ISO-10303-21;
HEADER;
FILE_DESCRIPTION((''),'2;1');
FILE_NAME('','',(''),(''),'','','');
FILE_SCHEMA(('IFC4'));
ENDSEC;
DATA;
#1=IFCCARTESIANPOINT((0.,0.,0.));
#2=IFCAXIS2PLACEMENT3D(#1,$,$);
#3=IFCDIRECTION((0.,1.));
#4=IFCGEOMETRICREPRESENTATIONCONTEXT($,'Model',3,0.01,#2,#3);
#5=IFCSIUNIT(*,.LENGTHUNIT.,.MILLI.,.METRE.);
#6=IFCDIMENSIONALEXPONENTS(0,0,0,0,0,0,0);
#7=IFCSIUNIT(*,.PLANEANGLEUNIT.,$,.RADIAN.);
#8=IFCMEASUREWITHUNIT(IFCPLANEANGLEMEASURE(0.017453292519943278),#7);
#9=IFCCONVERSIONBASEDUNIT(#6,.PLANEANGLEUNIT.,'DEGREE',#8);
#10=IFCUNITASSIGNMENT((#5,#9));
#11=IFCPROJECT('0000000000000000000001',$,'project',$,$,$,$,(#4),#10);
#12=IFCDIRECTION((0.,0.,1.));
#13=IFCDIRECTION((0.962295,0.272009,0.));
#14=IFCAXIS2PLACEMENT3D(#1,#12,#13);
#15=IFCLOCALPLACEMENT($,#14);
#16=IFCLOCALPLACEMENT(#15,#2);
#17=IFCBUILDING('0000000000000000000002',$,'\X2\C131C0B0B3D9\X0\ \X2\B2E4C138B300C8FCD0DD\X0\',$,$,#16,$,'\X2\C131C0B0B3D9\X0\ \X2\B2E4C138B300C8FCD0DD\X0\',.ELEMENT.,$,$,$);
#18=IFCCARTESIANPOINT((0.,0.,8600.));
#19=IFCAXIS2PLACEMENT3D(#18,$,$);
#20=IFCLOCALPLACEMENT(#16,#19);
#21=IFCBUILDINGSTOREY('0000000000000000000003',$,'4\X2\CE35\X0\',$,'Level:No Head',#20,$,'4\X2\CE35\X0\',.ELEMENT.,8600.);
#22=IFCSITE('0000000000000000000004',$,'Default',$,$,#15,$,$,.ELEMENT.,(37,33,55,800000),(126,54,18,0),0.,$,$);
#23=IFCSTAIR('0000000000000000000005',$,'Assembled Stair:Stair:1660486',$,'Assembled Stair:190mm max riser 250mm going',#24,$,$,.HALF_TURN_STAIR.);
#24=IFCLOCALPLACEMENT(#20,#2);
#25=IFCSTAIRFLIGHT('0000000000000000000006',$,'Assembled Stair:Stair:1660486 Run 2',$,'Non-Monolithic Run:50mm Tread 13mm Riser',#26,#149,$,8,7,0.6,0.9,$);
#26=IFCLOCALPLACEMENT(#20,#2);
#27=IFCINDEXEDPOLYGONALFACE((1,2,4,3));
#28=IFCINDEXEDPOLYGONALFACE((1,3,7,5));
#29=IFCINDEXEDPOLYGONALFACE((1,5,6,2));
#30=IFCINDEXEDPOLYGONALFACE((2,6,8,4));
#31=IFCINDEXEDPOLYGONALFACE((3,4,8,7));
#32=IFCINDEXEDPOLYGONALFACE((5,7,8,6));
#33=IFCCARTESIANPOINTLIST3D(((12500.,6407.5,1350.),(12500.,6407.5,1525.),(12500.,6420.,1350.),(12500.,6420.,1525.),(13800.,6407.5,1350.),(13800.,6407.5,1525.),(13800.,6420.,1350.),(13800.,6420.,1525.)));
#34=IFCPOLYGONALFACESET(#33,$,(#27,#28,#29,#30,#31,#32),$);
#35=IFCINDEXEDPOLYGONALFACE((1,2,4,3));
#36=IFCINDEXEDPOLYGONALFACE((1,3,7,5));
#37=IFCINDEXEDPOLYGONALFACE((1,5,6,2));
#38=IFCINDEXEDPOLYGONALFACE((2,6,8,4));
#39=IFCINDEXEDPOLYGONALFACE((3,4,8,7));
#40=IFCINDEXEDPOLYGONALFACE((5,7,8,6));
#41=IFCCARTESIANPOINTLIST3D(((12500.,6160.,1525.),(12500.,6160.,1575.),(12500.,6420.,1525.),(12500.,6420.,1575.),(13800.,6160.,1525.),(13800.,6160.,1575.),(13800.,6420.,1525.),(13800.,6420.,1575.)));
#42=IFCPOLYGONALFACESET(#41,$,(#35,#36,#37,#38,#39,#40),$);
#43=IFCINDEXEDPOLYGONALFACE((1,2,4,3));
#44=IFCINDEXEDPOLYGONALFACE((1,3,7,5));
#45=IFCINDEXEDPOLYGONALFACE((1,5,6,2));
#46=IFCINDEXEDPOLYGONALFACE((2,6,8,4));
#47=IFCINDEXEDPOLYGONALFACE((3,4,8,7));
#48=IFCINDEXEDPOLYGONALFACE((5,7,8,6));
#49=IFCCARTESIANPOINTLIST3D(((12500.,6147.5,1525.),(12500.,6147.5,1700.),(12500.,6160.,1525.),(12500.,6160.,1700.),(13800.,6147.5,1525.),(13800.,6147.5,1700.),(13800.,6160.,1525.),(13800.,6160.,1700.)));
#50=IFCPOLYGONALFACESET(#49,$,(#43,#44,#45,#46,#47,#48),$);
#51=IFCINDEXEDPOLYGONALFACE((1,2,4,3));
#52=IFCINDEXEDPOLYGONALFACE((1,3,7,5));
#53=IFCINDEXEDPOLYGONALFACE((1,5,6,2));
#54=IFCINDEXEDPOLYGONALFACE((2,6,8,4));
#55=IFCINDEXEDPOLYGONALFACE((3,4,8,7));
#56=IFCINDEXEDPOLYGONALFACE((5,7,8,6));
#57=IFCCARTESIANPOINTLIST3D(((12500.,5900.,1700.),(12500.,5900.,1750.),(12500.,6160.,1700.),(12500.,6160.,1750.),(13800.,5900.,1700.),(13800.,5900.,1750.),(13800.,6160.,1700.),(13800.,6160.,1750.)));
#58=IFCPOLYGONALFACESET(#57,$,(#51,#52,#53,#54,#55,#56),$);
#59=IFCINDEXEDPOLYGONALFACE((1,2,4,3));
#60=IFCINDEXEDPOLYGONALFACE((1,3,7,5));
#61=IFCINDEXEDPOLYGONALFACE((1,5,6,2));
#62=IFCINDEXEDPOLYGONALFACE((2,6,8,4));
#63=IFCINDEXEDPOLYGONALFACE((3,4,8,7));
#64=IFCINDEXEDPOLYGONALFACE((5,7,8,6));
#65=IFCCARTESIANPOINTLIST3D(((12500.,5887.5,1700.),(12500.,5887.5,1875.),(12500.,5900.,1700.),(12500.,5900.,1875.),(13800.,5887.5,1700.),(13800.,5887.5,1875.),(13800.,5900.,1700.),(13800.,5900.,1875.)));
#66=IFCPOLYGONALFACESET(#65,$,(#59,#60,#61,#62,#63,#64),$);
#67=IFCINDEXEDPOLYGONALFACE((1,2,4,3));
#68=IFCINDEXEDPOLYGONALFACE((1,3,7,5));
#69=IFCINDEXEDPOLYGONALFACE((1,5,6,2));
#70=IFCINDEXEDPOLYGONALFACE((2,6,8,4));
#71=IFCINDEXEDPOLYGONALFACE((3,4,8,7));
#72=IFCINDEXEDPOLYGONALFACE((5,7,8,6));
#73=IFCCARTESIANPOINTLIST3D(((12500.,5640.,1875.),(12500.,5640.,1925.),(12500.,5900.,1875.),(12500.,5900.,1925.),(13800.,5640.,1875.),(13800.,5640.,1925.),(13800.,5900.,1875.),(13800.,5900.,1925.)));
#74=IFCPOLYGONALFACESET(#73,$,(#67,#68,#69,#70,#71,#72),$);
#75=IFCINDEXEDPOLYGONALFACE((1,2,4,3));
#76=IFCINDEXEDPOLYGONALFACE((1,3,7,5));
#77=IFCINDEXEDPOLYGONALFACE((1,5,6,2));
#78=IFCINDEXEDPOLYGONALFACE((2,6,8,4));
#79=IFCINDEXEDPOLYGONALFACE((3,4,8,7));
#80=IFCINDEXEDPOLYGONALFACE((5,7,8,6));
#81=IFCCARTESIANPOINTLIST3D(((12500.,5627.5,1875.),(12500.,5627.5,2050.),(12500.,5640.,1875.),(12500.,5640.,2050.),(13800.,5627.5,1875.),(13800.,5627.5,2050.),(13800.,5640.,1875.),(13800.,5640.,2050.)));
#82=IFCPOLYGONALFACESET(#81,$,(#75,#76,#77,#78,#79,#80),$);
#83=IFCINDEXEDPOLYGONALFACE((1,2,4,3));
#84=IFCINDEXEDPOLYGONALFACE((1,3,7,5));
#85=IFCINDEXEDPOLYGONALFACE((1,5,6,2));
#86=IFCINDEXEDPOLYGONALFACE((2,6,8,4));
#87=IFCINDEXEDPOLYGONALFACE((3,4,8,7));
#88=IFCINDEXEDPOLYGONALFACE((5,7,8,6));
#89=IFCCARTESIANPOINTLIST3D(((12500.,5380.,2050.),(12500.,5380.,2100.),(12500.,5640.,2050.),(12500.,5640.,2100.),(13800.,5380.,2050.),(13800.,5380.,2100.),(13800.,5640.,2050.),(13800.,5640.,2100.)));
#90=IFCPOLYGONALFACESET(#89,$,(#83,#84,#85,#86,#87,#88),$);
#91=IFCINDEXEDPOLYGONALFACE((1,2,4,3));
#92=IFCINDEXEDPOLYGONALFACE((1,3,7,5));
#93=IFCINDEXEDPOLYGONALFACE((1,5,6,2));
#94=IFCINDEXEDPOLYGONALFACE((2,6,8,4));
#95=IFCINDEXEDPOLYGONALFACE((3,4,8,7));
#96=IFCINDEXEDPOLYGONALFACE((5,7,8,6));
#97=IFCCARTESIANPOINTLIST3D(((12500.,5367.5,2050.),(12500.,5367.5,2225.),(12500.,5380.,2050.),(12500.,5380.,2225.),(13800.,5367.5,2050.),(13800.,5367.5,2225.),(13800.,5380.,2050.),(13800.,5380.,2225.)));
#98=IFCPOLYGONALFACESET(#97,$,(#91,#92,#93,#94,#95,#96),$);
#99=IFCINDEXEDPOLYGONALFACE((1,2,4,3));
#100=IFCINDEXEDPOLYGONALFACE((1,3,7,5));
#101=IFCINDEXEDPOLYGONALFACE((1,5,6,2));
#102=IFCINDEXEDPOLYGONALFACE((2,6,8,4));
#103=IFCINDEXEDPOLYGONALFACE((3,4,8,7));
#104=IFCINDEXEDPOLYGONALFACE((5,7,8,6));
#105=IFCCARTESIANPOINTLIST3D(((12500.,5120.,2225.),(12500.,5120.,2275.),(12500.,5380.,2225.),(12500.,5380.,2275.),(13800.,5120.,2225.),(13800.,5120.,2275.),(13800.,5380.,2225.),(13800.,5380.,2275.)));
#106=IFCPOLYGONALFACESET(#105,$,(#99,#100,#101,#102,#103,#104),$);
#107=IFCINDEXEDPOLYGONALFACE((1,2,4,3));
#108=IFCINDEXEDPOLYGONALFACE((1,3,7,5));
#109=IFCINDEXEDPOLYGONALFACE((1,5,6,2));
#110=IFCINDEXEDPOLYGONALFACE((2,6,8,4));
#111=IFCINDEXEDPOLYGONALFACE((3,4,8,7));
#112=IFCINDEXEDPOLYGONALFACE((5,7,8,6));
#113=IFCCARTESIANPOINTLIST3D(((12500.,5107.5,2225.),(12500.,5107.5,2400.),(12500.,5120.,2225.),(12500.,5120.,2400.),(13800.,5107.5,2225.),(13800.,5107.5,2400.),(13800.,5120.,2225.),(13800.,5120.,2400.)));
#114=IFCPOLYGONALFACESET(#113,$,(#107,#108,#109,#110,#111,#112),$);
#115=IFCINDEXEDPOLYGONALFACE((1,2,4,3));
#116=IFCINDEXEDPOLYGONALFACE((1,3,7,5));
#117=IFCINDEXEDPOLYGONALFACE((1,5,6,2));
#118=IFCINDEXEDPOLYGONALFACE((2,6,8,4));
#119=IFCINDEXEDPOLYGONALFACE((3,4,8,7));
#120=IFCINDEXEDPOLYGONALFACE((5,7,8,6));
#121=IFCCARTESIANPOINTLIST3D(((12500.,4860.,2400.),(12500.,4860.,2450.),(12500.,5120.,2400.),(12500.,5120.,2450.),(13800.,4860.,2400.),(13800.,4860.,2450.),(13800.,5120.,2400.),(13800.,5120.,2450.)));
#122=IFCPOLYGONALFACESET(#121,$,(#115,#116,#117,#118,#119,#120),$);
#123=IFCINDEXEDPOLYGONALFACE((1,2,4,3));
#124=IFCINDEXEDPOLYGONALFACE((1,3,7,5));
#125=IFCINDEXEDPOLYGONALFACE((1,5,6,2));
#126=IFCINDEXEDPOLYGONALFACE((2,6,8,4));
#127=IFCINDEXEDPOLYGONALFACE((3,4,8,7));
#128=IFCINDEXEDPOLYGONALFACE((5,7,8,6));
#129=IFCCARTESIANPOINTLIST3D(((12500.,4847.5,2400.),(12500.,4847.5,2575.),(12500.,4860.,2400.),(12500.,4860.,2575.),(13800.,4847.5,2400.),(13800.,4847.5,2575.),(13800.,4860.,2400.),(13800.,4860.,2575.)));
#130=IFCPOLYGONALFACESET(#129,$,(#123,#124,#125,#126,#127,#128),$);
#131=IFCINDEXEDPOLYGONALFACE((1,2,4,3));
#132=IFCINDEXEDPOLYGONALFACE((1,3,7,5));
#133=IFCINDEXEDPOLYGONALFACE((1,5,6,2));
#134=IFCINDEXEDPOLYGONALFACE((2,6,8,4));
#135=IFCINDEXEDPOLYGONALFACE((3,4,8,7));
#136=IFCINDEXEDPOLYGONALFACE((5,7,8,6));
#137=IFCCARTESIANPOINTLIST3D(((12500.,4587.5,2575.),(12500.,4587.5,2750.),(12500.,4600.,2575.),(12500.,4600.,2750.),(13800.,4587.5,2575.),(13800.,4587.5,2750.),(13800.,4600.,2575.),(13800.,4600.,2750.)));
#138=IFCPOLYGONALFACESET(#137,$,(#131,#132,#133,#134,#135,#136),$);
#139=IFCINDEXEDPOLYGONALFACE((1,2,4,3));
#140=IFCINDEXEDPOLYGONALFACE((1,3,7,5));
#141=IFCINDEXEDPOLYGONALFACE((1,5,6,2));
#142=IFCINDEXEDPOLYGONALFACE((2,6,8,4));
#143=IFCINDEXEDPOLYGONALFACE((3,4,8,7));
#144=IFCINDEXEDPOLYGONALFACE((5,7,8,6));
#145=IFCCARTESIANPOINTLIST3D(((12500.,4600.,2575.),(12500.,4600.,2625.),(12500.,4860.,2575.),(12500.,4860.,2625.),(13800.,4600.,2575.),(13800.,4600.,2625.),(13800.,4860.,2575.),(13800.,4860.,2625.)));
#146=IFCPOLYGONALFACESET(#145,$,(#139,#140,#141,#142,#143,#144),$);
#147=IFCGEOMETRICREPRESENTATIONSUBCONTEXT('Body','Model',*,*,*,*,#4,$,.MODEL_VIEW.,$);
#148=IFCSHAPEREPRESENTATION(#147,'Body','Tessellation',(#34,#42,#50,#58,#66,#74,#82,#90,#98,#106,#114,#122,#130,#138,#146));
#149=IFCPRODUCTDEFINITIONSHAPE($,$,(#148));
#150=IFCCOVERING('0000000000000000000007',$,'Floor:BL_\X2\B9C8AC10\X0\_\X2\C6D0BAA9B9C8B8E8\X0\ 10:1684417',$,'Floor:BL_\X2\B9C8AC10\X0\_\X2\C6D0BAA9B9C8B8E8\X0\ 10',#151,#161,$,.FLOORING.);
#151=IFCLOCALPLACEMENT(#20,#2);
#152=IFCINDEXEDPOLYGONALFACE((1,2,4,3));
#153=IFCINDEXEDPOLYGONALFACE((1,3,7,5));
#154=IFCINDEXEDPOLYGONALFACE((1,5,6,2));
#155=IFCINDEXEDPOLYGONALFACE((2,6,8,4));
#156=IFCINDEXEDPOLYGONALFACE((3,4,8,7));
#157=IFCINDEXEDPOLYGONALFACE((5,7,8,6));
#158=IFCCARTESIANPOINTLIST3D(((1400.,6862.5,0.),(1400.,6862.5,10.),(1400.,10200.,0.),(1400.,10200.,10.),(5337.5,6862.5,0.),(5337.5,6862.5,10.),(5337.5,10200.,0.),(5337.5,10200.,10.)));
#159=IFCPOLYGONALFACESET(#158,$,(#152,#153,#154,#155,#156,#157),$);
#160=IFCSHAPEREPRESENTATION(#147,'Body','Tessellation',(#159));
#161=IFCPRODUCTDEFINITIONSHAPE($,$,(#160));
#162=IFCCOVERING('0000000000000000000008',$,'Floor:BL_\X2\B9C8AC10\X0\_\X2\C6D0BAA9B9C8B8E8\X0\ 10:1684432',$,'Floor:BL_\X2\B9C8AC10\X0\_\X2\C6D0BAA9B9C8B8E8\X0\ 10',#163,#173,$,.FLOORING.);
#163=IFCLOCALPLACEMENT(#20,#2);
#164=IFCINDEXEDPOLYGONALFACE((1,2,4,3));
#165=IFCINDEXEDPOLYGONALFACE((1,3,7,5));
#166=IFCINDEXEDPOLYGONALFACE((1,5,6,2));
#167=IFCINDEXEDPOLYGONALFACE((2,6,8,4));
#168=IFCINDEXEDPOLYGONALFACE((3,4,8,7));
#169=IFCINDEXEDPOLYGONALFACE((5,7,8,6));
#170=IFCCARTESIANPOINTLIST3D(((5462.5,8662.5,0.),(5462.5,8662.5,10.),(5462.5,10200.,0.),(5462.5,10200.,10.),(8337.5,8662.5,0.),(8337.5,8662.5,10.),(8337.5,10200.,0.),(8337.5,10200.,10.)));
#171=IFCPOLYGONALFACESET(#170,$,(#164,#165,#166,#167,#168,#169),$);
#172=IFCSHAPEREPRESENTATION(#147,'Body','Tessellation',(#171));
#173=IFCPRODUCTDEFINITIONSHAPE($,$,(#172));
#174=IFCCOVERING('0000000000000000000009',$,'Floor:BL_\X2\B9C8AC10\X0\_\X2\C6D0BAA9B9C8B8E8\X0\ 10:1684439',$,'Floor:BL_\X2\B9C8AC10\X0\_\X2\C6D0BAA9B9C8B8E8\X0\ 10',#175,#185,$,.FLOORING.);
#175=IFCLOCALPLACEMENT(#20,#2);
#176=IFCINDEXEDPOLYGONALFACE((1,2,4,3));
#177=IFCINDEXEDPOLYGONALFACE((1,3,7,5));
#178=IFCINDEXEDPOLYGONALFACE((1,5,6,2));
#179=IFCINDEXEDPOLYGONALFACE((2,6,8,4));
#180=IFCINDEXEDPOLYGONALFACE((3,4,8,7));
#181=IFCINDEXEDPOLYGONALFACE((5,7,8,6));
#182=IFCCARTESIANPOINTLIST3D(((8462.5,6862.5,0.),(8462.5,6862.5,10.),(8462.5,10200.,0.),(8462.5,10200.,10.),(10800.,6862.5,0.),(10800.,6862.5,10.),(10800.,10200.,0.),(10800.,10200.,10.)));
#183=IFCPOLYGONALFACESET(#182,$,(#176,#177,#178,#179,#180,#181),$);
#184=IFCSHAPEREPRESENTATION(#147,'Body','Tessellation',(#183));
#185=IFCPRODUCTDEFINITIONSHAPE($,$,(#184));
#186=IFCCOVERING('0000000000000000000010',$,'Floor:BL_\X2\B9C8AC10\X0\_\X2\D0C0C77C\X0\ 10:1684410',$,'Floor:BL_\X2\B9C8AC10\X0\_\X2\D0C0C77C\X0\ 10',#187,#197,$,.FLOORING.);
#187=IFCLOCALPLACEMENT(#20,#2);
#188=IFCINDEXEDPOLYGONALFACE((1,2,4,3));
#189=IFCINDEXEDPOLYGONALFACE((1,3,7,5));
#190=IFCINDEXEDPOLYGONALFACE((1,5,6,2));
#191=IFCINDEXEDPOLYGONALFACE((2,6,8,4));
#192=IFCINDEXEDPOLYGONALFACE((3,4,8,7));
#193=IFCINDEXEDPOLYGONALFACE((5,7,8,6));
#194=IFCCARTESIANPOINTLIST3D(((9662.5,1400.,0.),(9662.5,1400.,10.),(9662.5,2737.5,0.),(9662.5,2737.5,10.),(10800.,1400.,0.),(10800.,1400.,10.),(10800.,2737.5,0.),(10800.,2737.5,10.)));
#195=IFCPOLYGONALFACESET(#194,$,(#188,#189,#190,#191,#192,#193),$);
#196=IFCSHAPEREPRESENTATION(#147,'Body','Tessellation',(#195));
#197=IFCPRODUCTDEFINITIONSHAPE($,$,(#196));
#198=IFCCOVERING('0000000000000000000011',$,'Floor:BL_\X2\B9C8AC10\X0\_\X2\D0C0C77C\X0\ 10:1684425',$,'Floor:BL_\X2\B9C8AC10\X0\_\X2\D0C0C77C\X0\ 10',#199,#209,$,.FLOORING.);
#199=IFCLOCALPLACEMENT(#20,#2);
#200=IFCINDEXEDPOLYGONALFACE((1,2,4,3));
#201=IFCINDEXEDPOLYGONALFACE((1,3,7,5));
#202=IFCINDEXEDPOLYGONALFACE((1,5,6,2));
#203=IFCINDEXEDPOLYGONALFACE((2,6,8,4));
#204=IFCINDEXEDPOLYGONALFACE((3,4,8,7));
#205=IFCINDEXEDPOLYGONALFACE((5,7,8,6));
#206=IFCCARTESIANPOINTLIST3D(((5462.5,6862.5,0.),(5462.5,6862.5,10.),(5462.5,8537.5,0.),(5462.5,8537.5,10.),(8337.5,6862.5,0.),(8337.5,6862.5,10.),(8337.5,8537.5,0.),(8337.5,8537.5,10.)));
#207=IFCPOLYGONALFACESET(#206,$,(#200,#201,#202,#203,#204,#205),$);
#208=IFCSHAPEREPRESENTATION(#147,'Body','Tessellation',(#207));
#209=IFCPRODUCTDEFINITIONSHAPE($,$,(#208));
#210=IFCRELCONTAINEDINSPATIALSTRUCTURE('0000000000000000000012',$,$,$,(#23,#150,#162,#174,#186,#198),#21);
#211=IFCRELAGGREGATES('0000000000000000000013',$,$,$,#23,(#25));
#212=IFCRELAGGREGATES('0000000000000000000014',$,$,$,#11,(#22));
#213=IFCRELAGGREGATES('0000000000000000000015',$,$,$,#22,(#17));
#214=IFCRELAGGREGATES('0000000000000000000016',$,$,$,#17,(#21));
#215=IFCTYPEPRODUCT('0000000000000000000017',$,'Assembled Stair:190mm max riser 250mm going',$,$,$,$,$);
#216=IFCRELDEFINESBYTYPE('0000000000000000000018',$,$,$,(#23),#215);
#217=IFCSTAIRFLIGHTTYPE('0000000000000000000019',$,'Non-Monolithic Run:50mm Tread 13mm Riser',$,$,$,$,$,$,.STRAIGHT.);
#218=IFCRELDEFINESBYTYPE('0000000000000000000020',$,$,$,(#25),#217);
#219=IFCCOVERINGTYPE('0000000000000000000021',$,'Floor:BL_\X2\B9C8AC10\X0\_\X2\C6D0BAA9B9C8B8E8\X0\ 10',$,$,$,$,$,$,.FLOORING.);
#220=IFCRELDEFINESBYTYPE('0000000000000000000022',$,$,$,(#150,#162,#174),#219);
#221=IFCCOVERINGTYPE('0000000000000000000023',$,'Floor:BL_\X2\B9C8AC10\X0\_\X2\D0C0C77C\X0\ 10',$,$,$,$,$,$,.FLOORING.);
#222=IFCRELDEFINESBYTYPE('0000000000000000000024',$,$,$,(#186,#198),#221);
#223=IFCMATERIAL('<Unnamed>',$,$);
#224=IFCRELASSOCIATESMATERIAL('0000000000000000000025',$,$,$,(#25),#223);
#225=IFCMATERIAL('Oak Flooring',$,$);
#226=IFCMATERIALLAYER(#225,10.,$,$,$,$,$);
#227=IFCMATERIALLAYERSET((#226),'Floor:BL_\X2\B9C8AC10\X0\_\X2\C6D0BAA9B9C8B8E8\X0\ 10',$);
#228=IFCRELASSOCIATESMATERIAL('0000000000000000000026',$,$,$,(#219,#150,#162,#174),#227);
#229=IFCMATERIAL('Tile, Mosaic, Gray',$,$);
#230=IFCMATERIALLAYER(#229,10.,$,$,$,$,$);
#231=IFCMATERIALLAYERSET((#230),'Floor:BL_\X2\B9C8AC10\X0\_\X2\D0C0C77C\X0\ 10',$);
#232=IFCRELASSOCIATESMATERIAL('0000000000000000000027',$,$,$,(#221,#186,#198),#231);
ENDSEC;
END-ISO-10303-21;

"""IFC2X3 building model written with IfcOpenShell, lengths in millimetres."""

from ifc_helpers import new_model, entity, si_unit, converted_unit, direction, frame, frame_2d, origin, origin_2d_with_axis, place, context, subcontext, project, spatial, rectangle, extrude, material, layer, layer_set, layer_usage, type_object, element, aggregate, save


model = new_model("IFC2X3")

# Units and contexts
model_context = context("Model", 3, precision=0.01, world=origin(), true_north=direction((0.0, 1.0)))
body_context = subcontext(model_context, "Body", "Model", "MODEL_VIEW")
ifc_project = project(units=[si_unit("LENGTHUNIT", "METRE", prefix="MILLI"), converted_unit("PLANEANGLEUNIT", "DEGREE", entity("IfcPlaneAngleMeasure", 0.017453292519943278), si_unit("PLANEANGLEUNIT", "RADIAN"), dimensions=[0, 0, 0, 0, 0, 0, 0])], contexts=[model_context])

# Site, building, storey
site_placement = place(None, frame((0.0, 0.0, 0.0), z_axis=(0.0, 0.0, 1.0), x_axis=(0.962295, 0.272009, 0.0)))
site = spatial("IfcSite", under=ifc_project, at=site_placement, Name="Default", CompositionType="ELEMENT", RefLatitude=(37, 33, 55, 800000), RefLongitude=(126, 54, 18, 0), RefElevation=0.0)
building_placement = place(site_placement, origin())
building = spatial("IfcBuilding", under=site, at=building_placement, Name="성산동 다세대주택", LongName="성산동 다세대주택", CompositionType="ELEMENT")
storey_placement = place(building_placement, frame((0.0, 0.0, 8600.0)))
storey = spatial("IfcBuildingStorey", under=building, at=storey_placement, Name="4층", ObjectType="Level:No Head", LongName="4층", CompositionType="ELEMENT", Elevation=8600.0)

# Stair
type_product = type_object("IfcTypeProduct", Name="Assembled Stair:190mm max riser 250mm going")
stair_placement = place(storey_placement, origin())
stair = element("IfcStair", 1, at=stair_placement, inside=storey, type_object=type_product, Name="Assembled Stair:Stair:1660486", ObjectType="Assembled Stair:190mm max riser 250mm going", ShapeType="HALF_TURN_STAIR")
ifc_material_1 = material(Name="<Unnamed>")

# Stair flight
stair_flight_type = type_object("IfcStairFlightType", Name="Non-Monolithic Run:50mm Tread 13mm Riser", PredefinedType="STRAIGHT")
stair_flight_1_placement = place(stair_placement, origin())
stair_flight_1 = element("IfcStairFlight", 2, at=stair_flight_1_placement, type_object=stair_flight_type, material=ifc_material_1, Name="Assembled Stair:Stair:1660486 Run 2", ObjectType="Non-Monolithic Run:50mm Tread 13mm Riser", NumberOfRiser=8, NumberOfTreads=7, RiserHeight=0.6, TreadLength=0.9, context=body_context, shape_type="SweptSolid", body=[
    extrude(rectangle(XDim=1300.0, YDim=12.5, at=frame_2d((0.0, 0.0), x_axis=(1.0, 0.0))), frame((13150.0, 6413.7, 1350.0)), (0.0, 0.0, 1.0), 175.0),
    extrude(rectangle(XDim=260.0, YDim=1300.0, at=frame_2d((0.0, 0.0), x_axis=(1.0, 0.0))), frame((13150.0, 6290.0, 1525.0), z_axis=(0.0, 0.0, 1.0), x_axis=(0.0, 1.0, 0.0)), (0.0, 0.0, 1.0), 50.0),
    extrude(rectangle(XDim=1300.0, YDim=12.5, at=frame_2d((0.0, 0.0), x_axis=(1.0, 0.0))), frame((13150.0, 6153.7, 1525.0)), (0.0, 0.0, 1.0), 175.0),
    extrude(rectangle(XDim=260.0, YDim=1300.0, at=origin_2d_with_axis()), frame((13150.0, 6030.0, 1700.0), z_axis=(0.0, 0.0, 1.0), x_axis=(0.0, 1.0, 0.0)), (0.0, 0.0, 1.0), 50.0),
    extrude(rectangle(XDim=1300.0, YDim=12.5, at=frame_2d((0.0, 0.0), x_axis=(1.0, 0.0))), frame((13150.0, 5893.7, 1700.0)), (0.0, 0.0, 1.0), 175.0),
    extrude(rectangle(XDim=260.0, YDim=1300.0, at=origin_2d_with_axis()), frame((13150.0, 5770.0, 1875.0), z_axis=(0.0, 0.0, 1.0), x_axis=(0.0, 1.0, 0.0)), (0.0, 0.0, 1.0), 50.0),
    extrude(rectangle(XDim=1300.0, YDim=12.5, at=frame_2d((0.0, 0.0), x_axis=(1.0, 0.0))), frame((13150.0, 5633.7, 1875.0)), (0.0, 0.0, 1.0), 175.0),
    extrude(rectangle(XDim=260.0, YDim=1300.0, at=origin_2d_with_axis()), frame((13150.0, 5510.0, 2050.0), z_axis=(0.0, 0.0, 1.0), x_axis=(0.0, 1.0, 0.0)), (0.0, 0.0, 1.0), 50.0),
    extrude(rectangle(XDim=1300.0, YDim=12.5, at=frame_2d((0.0, 0.0), x_axis=(1.0, 0.0))), frame((13150.0, 5373.7, 2050.0)), (0.0, 0.0, 1.0), 175.0),
    extrude(rectangle(XDim=260.0, YDim=1300.0, at=origin_2d_with_axis()), frame((13150.0, 5250.0, 2225.0), z_axis=(0.0, 0.0, 1.0), x_axis=(0.0, 1.0, 0.0)), (0.0, 0.0, 1.0), 50.0),
    extrude(rectangle(XDim=1300.0, YDim=12.5, at=frame_2d((0.0, 0.0), x_axis=(1.0, 0.0))), frame((13150.0, 5113.7, 2225.0)), (0.0, 0.0, 1.0), 175.0),
    extrude(rectangle(XDim=260.0, YDim=1300.0, at=origin_2d_with_axis()), frame((13150.0, 4990.0, 2400.0), z_axis=(0.0, 0.0, 1.0), x_axis=(0.0, 1.0, 0.0)), (0.0, 0.0, 1.0), 50.0),
    extrude(rectangle(XDim=1300.0, YDim=12.5, at=frame_2d((0.0, 0.0), x_axis=(1.0, 0.0))), frame((13150.0, 4853.7, 2400.0)), (0.0, 0.0, 1.0), 175.0),
    extrude(rectangle(XDim=1300.0, YDim=12.5, at=frame_2d((0.0, 0.0), x_axis=(1.0, 0.0))), frame((13150.0, 4593.8, 2575.0)), (0.0, 0.0, 1.0), 175.0),
    extrude(rectangle(XDim=260.0, YDim=1300.0, at=origin_2d_with_axis()), frame((13150.0, 4730.0, 2575.0), z_axis=(0.0, 0.0, 1.0), x_axis=(0.0, 1.0, 0.0)), (0.0, 0.0, 1.0), 50.0),
])
aggregate(stair, [stair_flight_1])

# Coverings
ifc_material_2 = material(Name="Oak Flooring")
ifc_layer_1 = layer(ifc_material_2, 10.0)
ifc_layer_set_1 = layer_set([ifc_layer_1], Name="Floor:BL_마감_원목마루 10")
covering_type_1 = type_object("IfcCoveringType", Name="Floor:BL_마감_원목마루 10", PredefinedType="FLOORING", material=ifc_layer_set_1)
ifc_layer_usage_1 = layer_usage(ifc_layer_set_1, "AXIS3", "POSITIVE", 0.0)
covering_1_placement = place(storey_placement, origin())
element("IfcCovering", 3, at=covering_1_placement, inside=storey, type_object=covering_type_1, material=ifc_layer_usage_1, Name="Floor:BL_마감_원목마루 10:1684417", ObjectType="Floor:BL_마감_원목마루 10", PredefinedType="FLOORING", context=body_context, shape_type="SweptSolid", body=[
    extrude(rectangle(XDim=3337.5, YDim=3937.5, at=frame_2d((0.0, 0.0), x_axis=(1.0, 0.0))), frame((3368.8, 8531.3, 10.0), z_axis=(0.0, 0.0, -1.0), x_axis=(0.0, 1.0, 0.0)), (0.0, 0.0, 1.0), 10.0),
])
ifc_layer_usage_2 = layer_usage(ifc_layer_set_1, "AXIS3", "POSITIVE", 0.0)
covering_2_placement = place(storey_placement, origin())
element("IfcCovering", 4, at=covering_2_placement, inside=storey, type_object=covering_type_1, material=ifc_layer_usage_2, Name="Floor:BL_마감_원목마루 10:1684432", ObjectType="Floor:BL_마감_원목마루 10", PredefinedType="FLOORING", context=body_context, shape_type="SweptSolid", body=[
    extrude(rectangle(XDim=1537.5, YDim=2875.0, at=frame_2d((0.0, 0.0), x_axis=(1.0, 0.0))), frame((6900.0, 9431.2, 10.0), z_axis=(0.0, 0.0, -1.0), x_axis=(0.0, 1.0, 0.0)), (0.0, 0.0, 1.0), 10.0),
])
ifc_layer_usage_3 = layer_usage(ifc_layer_set_1, "AXIS3", "POSITIVE", 0.0)
covering_3_placement = place(storey_placement, origin())
element("IfcCovering", 5, at=covering_3_placement, inside=storey, type_object=covering_type_1, material=ifc_layer_usage_3, Name="Floor:BL_마감_원목마루 10:1684439", ObjectType="Floor:BL_마감_원목마루 10", PredefinedType="FLOORING", context=body_context, shape_type="SweptSolid", body=[
    extrude(rectangle(XDim=2337.5, YDim=3337.5, at=frame_2d((0.0, 0.0), x_axis=(1.0, 0.0))), frame((9631.2, 8531.2, 10.0), z_axis=(0.0, 0.0, -1.0), x_axis=(1.0, 0.0, 0.0)), (0.0, 0.0, 1.0), 10.0),
])
ifc_material_3 = material(Name="Tile, Mosaic, Gray")
ifc_layer_2 = layer(ifc_material_3, 10.0)
ifc_layer_set_2 = layer_set([ifc_layer_2], Name="Floor:BL_마감_타일 10")
ifc_layer_usage_4 = layer_usage(ifc_layer_set_2, "AXIS3", "POSITIVE", 0.0)
covering_type_2 = type_object("IfcCoveringType", Name="Floor:BL_마감_타일 10", PredefinedType="FLOORING", material=ifc_layer_set_2)
covering_4_placement = place(storey_placement, origin())
element("IfcCovering", 6, at=covering_4_placement, inside=storey, type_object=covering_type_2, material=ifc_layer_usage_4, Name="Floor:BL_마감_타일 10:1684410", ObjectType="Floor:BL_마감_타일 10", PredefinedType="FLOORING", context=body_context, shape_type="SweptSolid", body=[
    extrude(rectangle(XDim=1337.5, YDim=1137.5, at=frame_2d((0.0, 0.0), x_axis=(1.0, 0.0))), frame((10231.2, 2068.8, 10.0), z_axis=(0.0, 0.0, -1.0), x_axis=(0.0, 1.0, 0.0)), (0.0, 0.0, 1.0), 10.0),
])
ifc_layer_usage_5 = layer_usage(ifc_layer_set_2, "AXIS3", "POSITIVE", 0.0)
covering_5_placement = place(storey_placement, origin())
element("IfcCovering", 7, at=covering_5_placement, inside=storey, type_object=covering_type_2, material=ifc_layer_usage_5, Name="Floor:BL_마감_타일 10:1684425", ObjectType="Floor:BL_마감_타일 10", PredefinedType="FLOORING", context=body_context, shape_type="SweptSolid", body=[
    extrude(rectangle(XDim=1675.0, YDim=2875.0, at=frame_2d((0.0, 0.0), x_axis=(1.0, 0.0))), frame((6900.0, 7700.0, 10.0), z_axis=(0.0, 0.0, -1.0), x_axis=(0.0, 1.0, 0.0)), (0.0, 0.0, 1.0), 10.0),
])

save(model, "model.ifc")
